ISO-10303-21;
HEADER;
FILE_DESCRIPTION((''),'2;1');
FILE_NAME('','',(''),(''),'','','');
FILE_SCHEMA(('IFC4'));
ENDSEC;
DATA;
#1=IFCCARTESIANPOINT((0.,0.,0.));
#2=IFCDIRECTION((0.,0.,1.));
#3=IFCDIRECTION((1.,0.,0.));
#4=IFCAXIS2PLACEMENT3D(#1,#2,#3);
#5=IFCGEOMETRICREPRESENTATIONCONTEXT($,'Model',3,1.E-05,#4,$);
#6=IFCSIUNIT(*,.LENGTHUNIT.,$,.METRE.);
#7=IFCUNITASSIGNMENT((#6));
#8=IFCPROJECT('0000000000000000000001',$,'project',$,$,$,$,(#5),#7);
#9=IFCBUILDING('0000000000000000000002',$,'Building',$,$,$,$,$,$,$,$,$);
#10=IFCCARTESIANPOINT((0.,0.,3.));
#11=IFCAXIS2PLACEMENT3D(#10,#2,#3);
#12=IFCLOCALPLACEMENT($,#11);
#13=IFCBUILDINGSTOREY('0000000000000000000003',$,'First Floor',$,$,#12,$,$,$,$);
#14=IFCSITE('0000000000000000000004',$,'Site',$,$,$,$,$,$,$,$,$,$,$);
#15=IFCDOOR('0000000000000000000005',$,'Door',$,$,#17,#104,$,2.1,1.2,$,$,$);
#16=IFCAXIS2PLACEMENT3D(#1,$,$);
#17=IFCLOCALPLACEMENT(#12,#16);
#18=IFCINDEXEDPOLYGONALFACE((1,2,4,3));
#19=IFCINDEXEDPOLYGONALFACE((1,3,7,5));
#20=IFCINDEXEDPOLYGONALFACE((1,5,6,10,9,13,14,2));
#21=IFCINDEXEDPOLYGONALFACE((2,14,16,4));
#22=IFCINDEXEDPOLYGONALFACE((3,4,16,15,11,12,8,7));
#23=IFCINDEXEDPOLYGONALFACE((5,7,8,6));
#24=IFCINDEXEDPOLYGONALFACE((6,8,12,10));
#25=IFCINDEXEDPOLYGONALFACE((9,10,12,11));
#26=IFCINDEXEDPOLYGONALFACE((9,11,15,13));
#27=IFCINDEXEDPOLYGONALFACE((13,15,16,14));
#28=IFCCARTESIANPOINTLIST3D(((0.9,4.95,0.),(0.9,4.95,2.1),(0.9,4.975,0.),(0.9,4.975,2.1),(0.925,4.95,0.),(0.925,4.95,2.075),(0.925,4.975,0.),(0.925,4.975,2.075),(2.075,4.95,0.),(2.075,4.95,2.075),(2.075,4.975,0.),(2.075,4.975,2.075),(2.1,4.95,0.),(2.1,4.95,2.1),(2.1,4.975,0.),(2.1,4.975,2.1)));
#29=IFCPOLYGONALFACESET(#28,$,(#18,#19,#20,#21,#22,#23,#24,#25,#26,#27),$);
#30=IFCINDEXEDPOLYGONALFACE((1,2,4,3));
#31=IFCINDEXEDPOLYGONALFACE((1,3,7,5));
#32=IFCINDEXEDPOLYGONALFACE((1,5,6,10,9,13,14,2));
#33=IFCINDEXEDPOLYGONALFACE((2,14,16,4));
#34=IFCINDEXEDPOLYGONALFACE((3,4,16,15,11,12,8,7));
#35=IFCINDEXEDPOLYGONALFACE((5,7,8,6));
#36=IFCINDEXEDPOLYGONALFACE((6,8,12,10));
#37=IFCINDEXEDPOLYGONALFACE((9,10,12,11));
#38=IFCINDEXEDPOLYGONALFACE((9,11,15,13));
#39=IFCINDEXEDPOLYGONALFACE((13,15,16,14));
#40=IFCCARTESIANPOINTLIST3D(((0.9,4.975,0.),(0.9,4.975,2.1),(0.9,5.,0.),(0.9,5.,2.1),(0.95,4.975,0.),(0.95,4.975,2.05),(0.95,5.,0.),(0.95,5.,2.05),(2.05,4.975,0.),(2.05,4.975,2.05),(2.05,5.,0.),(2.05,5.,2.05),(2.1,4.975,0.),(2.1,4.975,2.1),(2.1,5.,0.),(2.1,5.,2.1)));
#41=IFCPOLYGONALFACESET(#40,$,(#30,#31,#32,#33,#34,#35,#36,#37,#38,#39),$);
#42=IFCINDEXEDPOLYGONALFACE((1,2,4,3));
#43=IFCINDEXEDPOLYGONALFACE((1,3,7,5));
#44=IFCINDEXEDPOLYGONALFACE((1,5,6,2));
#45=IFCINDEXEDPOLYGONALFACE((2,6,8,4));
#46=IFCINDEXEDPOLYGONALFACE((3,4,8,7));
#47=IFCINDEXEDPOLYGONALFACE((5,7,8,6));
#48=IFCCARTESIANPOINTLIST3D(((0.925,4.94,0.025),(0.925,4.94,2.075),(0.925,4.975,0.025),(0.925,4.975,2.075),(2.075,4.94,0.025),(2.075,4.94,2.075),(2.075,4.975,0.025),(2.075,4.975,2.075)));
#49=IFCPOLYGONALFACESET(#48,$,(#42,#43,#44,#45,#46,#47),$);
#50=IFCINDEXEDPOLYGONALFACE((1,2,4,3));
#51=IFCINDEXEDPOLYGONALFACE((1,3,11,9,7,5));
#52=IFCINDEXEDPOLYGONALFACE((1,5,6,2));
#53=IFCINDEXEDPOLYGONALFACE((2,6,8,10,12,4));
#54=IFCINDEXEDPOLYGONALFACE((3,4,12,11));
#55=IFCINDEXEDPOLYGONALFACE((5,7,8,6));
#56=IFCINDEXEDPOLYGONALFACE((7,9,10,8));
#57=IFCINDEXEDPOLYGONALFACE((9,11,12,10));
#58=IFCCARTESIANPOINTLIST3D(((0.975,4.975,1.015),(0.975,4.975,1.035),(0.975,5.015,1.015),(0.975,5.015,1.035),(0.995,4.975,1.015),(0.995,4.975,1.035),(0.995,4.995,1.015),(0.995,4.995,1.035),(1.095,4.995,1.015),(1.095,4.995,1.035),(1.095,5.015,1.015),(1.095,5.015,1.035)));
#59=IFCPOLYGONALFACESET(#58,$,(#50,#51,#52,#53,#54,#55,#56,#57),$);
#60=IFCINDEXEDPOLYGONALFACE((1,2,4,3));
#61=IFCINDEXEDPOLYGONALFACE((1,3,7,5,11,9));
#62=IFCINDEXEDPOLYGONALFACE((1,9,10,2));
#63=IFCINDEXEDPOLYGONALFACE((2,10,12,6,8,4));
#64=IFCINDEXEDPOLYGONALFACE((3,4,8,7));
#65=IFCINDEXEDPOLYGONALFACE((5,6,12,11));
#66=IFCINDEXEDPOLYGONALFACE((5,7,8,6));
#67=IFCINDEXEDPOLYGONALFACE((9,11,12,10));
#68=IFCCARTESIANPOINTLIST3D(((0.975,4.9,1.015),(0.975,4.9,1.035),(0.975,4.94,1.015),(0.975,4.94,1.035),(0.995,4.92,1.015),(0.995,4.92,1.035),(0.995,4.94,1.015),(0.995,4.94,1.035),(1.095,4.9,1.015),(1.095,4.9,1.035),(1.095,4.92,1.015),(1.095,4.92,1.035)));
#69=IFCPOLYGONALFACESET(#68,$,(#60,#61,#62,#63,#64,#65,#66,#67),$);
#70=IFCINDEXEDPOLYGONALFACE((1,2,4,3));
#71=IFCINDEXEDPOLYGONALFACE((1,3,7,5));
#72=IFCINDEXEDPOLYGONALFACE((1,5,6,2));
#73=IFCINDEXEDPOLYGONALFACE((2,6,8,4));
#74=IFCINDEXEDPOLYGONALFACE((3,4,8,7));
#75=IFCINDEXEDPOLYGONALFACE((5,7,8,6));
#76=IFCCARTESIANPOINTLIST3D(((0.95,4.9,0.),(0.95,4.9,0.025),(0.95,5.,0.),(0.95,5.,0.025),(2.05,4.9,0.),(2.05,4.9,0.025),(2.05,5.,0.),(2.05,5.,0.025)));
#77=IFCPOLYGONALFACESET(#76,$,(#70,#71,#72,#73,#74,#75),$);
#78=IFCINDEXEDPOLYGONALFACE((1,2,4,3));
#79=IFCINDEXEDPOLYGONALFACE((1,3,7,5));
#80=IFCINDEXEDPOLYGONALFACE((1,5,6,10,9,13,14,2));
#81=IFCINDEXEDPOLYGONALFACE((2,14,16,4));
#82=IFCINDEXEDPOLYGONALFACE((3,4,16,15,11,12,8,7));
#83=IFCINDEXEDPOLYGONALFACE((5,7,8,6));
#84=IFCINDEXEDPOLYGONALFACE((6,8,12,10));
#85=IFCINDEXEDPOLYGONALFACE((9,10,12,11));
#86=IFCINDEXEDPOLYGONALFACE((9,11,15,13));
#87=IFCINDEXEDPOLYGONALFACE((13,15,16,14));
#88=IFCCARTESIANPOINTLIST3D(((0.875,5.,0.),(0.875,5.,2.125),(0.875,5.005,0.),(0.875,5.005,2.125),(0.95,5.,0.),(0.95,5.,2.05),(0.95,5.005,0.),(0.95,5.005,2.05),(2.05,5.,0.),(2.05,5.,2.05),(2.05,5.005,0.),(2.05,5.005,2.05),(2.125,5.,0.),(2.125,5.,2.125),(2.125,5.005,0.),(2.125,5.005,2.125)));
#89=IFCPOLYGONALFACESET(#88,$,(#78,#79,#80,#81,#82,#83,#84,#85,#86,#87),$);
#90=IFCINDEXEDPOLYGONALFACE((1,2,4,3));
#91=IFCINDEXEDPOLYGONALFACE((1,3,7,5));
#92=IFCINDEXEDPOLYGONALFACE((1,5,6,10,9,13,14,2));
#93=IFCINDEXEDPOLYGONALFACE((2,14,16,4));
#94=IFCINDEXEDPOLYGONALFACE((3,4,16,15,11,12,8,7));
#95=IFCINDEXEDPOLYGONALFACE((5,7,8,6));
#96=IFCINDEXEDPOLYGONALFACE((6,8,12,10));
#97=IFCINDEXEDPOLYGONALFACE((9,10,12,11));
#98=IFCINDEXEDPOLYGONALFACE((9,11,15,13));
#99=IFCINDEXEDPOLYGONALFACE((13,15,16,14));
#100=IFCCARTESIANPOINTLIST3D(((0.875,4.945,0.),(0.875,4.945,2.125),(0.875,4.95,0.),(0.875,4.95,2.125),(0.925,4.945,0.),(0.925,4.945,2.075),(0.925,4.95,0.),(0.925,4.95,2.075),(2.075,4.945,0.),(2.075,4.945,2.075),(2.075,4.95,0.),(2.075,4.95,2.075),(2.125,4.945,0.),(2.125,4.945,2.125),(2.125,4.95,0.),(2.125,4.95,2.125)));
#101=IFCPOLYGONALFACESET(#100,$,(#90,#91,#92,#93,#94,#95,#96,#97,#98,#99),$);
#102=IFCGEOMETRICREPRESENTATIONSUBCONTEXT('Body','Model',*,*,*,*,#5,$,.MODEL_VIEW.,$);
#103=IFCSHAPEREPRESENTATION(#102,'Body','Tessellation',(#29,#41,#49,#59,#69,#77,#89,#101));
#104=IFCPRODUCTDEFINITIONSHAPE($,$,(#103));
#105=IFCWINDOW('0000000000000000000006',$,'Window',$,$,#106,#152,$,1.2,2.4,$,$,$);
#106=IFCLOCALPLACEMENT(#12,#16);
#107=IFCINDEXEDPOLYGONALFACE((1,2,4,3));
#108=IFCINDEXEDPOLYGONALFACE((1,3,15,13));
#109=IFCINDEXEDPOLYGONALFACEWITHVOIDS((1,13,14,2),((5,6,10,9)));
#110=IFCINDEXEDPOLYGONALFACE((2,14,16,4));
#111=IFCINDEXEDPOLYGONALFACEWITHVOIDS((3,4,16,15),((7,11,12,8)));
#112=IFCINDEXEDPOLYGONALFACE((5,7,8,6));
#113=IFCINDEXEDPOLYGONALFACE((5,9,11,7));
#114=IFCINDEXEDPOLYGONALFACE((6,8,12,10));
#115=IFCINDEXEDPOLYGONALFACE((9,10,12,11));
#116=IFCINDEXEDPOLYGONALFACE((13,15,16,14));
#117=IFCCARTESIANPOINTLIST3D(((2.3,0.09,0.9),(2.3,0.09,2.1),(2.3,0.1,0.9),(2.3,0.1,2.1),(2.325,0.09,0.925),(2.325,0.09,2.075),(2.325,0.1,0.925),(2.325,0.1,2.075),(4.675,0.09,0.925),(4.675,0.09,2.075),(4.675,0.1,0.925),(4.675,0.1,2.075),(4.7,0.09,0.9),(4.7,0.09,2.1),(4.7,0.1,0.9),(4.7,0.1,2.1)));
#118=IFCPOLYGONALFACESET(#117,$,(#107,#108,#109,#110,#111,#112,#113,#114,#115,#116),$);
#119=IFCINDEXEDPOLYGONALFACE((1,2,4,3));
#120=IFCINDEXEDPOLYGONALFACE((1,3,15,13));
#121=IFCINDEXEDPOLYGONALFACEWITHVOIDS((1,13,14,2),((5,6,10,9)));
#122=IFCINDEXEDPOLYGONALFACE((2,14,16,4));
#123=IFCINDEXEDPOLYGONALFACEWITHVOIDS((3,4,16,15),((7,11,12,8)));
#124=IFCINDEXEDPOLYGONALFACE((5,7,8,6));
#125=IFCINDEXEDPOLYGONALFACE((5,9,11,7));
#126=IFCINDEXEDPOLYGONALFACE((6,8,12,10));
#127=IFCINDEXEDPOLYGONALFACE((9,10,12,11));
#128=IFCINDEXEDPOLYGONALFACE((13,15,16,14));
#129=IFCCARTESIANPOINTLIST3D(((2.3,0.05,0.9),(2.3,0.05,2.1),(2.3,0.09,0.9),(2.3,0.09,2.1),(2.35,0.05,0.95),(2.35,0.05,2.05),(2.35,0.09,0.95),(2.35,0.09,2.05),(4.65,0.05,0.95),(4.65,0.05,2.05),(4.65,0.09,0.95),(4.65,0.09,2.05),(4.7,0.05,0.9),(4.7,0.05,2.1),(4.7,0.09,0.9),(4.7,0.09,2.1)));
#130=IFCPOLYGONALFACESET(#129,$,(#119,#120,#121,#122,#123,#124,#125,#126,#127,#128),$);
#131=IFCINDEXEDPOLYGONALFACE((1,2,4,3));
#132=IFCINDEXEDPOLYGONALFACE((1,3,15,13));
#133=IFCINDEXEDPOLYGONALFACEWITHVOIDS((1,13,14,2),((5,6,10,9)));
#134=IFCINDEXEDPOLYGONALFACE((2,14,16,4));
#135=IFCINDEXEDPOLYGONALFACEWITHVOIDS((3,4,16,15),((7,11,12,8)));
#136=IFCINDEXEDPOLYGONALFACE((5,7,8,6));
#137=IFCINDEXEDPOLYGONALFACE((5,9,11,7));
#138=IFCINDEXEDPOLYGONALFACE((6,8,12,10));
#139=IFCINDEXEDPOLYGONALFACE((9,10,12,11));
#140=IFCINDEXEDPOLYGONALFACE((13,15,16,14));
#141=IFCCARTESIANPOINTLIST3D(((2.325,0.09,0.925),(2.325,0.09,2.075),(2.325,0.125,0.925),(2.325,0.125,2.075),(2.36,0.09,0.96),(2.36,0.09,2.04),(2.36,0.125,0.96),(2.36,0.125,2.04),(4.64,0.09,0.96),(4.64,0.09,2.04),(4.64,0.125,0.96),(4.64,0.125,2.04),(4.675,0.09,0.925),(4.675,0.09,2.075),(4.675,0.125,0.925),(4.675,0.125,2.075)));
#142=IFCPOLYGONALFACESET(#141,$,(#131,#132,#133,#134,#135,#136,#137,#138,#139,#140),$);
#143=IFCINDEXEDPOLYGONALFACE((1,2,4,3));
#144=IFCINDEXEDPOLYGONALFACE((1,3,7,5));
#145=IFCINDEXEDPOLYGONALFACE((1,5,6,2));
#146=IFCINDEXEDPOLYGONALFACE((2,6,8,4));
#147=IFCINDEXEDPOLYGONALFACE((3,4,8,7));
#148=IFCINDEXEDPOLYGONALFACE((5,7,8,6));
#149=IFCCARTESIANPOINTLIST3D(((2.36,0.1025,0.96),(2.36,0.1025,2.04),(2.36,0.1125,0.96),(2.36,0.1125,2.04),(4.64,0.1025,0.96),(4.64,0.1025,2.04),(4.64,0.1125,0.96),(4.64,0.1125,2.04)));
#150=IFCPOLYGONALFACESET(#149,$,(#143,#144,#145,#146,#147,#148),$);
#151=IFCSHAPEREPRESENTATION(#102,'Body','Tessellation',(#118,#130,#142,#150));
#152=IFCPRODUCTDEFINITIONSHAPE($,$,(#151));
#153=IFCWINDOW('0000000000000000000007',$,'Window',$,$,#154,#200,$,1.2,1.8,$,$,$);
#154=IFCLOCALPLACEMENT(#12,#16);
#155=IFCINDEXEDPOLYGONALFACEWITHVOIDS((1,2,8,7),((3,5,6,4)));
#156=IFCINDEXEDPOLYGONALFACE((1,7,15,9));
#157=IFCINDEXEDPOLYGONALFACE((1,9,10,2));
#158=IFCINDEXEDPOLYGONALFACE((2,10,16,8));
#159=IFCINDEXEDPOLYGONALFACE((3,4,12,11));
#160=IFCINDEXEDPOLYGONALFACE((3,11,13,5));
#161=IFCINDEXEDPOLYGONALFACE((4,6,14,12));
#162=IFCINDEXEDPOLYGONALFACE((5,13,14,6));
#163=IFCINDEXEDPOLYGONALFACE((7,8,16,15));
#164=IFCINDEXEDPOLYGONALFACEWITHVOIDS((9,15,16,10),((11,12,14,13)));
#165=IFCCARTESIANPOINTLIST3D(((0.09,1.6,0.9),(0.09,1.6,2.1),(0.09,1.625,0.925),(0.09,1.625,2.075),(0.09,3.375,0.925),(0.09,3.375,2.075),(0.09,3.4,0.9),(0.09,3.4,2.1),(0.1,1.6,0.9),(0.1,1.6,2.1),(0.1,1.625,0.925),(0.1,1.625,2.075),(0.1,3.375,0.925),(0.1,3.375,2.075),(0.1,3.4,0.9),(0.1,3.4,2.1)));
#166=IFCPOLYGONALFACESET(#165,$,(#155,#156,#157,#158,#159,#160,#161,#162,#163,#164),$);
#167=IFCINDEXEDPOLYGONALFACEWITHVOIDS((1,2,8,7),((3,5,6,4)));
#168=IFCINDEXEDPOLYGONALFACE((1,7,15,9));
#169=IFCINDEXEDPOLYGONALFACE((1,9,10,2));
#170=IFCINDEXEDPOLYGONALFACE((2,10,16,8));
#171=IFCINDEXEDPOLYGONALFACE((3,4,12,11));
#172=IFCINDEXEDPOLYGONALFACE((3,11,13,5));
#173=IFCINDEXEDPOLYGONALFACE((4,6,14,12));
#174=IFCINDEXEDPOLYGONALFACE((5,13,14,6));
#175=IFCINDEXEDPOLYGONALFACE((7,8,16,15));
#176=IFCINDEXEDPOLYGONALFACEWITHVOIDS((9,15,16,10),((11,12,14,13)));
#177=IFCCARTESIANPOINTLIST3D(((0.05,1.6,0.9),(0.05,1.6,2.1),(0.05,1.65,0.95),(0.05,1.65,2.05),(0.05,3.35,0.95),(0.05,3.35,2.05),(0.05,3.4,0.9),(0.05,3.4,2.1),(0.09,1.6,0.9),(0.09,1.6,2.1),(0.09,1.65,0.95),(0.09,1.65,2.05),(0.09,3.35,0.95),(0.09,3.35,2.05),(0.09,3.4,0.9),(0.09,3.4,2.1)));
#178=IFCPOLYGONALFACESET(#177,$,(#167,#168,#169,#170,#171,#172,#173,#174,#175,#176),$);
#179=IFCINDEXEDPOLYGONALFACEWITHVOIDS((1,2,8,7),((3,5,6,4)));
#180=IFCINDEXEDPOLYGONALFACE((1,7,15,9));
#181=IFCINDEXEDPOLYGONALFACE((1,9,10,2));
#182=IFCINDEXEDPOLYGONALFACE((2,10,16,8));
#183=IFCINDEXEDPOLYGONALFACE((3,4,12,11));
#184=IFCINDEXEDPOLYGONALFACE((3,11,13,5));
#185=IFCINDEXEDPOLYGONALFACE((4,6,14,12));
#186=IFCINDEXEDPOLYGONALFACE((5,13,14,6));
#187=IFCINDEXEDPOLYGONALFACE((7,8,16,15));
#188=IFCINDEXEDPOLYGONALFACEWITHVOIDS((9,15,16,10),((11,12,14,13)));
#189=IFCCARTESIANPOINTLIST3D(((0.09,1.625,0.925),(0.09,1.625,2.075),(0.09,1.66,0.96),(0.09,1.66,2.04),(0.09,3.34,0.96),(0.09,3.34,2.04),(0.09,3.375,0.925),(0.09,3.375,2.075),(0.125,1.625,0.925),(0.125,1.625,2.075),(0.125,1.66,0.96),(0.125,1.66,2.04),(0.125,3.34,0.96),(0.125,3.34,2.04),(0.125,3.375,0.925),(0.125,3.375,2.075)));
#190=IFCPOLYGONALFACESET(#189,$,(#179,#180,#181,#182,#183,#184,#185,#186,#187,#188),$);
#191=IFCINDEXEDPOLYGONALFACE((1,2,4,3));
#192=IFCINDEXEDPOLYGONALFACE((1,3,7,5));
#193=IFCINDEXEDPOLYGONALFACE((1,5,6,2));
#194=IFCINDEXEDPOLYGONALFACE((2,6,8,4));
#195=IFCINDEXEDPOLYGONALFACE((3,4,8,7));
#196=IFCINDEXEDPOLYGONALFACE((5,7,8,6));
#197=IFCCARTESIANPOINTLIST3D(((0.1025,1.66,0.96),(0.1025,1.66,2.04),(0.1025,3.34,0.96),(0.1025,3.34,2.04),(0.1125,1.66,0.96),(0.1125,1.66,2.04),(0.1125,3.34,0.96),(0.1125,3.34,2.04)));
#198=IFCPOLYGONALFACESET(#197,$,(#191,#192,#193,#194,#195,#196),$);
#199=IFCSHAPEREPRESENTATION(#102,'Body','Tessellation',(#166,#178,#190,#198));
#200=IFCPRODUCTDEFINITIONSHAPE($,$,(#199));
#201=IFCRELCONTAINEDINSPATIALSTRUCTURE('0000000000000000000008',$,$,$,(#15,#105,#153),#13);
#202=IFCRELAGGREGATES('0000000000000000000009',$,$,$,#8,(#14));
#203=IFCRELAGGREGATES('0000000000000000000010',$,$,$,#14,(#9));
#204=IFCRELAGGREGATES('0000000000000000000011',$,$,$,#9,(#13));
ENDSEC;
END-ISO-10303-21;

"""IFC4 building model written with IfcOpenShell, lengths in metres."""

from ifc_helpers import new_model, si_unit, frame, origin_with_axes, place, context, subcontext, project, spatial, line, indexed_curve, outline, extrude, element, save


model = new_model("IFC4")

# Units and contexts
model_context = context("Model", 3, precision=1e-05, world=origin_with_axes())
body_context = subcontext(model_context, "Body", "Model", "MODEL_VIEW")
ifc_project = project(units=[si_unit("LENGTHUNIT", "METRE")], contexts=[model_context])

# Site, building, storey
site = spatial("IfcSite", under=ifc_project, Name="Site")
building = spatial("IfcBuilding", under=site, Name="Building")
storey_placement = place(None, frame((0.0, 0.0, 3.0), z_axis=(0.0, 0.0, 1.0), x_axis=(1.0, 0.0, 0.0)))
storey = spatial("IfcBuildingStorey", under=building, at=storey_placement, Name="First Floor")

# Door
door_1_placement = place(storey_placement, frame((2.1, 5.0, 0.0), z_axis=(0.0, 0.0, 1.0), x_axis=(-1.0, 0.0, 0.0)))
element("IfcDoor", 1, at=door_1_placement, inside=storey, Name="Door", OverallHeight=2.1, OverallWidth=1.2, context=body_context, shape_type="SweptSolid", body=[
    extrude(outline(indexed_curve([(0.0, 0.0), (0.0, 2.1), (1.2, 2.1), (1.2, 0.0), (1.175, 0.0), (1.175, 2.075), (0.025, 2.075), (0.025, 0.0)], segments=[line(1, 2, 3, 4, 5, 6, 7, 8, 1)])), frame((0.0, 0.025, 0.0), z_axis=(0.0, -1.0, 0.0), x_axis=(1.0, 0.0, 0.0)), (0.0, 0.0, -1.0), 0.025),
    extrude(outline(indexed_curve([(0.0, 0.0), (0.0, 2.1), (1.2, 2.1), (1.2, 0.0), (1.15, 0.0), (1.15, 2.05), (0.05, 2.05), (0.05, 0.0)], segments=[line(1, 2, 3, 4, 5, 6, 7, 8, 1)])), frame((0.0, 0.0, 0.0), z_axis=(0.0, -1.0, 0.0), x_axis=(1.0, 0.0, 0.0)), (0.0, 0.0, -1.0), 0.025),
    extrude(outline(indexed_curve([(0.0, 0.0), (1.15, 0.0), (1.15, 0.035), (0.0, 0.035)], segments=[line(1, 2, 3, 4, 1)])), frame((0.025, 0.025, 0.025), z_axis=(0.0, 0.0, 1.0), x_axis=(1.0, 0.0, 0.0)), (0.0, 0.0, 1.0), 2.05),
    extrude(outline(indexed_curve([(0.0, 0.0), (0.0, -0.04), (-0.12, -0.04), (-0.12, -0.02), (-0.02, -0.02), (-0.02, 0.0)], segments=[line(1, 2, 3, 4, 5, 6, 1)])), frame((1.125, 0.025, 1.015), z_axis=(0.0, 0.0, 1.0), x_axis=(1.0, 0.0, 0.0)), (0.0, 0.0, 1.0), 0.02),
    extrude(outline(indexed_curve([(0.0, 0.0), (0.0, 0.04), (-0.12, 0.04), (-0.12, 0.02), (-0.02, 0.02), (-0.02, 0.0)], segments=[line(1, 2, 3, 4, 5, 6, 1)])), frame((1.125, 0.06, 1.015), z_axis=(0.0, 0.0, 1.0), x_axis=(1.0, 0.0, 0.0)), (0.0, 0.0, 1.0), 0.02),
    extrude(outline(indexed_curve([(0.0, 0.0), (1.1, 0.0), (1.1, 0.1), (0.0, 0.1)], segments=[line(1, 2, 3, 4, 1)])), frame((0.05, 0.0, 0.0), z_axis=(0.0, 0.0, 1.0), x_axis=(1.0, 0.0, 0.0)), (0.0, 0.0, 1.0), 0.025),
    extrude(outline(indexed_curve([(0.0, 0.0), (0.0, 2.125), (1.25, 2.125), (1.25, 0.0), (1.175, 0.0), (1.175, 2.05), (0.075, 2.05), (0.075, 0.0)], segments=[line(1, 2, 3, 4, 5, 6, 7, 8, 1)])), frame((-0.025, -0.005, 0.0), z_axis=(0.0, -1.0, 0.0), x_axis=(1.0, 0.0, 0.0)), (0.0, 0.0, -1.0), 0.005),
    extrude(outline(indexed_curve([(0.0, 0.0), (0.0, 2.125), (1.25, 2.125), (1.25, 0.0), (1.2, 0.0), (1.2, 2.075), (0.05, 2.075), (0.05, 0.0)], segments=[line(1, 2, 3, 4, 5, 6, 7, 8, 1)])), frame((-0.025, 0.05, 0.0), z_axis=(0.0, -1.0, 0.0), x_axis=(1.0, 0.0, 0.0)), (0.0, 0.0, -1.0), 0.005),
])

# Windows
window_1_placement = place(storey_placement, frame((2.3, 0.0, 0.9), z_axis=(0.0, 0.0, 1.0), x_axis=(1.0, 0.0, 0.0)))
element("IfcWindow", 2, at=window_1_placement, inside=storey, Name="Window", OverallHeight=1.2, OverallWidth=2.4, context=body_context, shape_type="SweptSolid", body=[
    extrude(outline(indexed_curve([(0.0, 0.0), (2.4, 0.0), (2.4, 1.2), (0.0, 1.2)], segments=[line(1, 2, 3, 4, 1)]), holes=[indexed_curve([(0.025, 0.025), (2.375, 0.025), (2.375, 1.175), (0.025, 1.175)], segments=[line(1, 2, 3, 4, 1)])]), frame((0.0, 0.09, 0.0), z_axis=(0.0, -1.0, 0.0), x_axis=(1.0, 0.0, 0.0)), (0.0, 0.0, -1.0), 0.01),
    extrude(outline(indexed_curve([(0.0, 0.0), (2.4, 0.0), (2.4, 1.2), (0.0, 1.2)], segments=[line(1, 2, 3, 4, 1)]), holes=[indexed_curve([(0.05, 0.05), (2.35, 0.05), (2.35, 1.15), (0.05, 1.15)], segments=[line(1, 2, 3, 4, 1)])]), frame((0.0, 0.05, 0.0), z_axis=(0.0, -1.0, 0.0), x_axis=(1.0, 0.0, 0.0)), (0.0, 0.0, -1.0), 0.04),
    extrude(outline(indexed_curve([(0.0, 0.0), (2.35, 0.0), (2.35, 1.15), (0.0, 1.15)], segments=[line(1, 2, 3, 4, 1)]), holes=[indexed_curve([(0.035, 0.035), (2.315, 0.035), (2.315, 1.115), (0.035, 1.115)], segments=[line(1, 2, 3, 4, 1)])]), frame((0.025, 0.09, 0.025), z_axis=(0.0, -1.0, 0.0), x_axis=(1.0, 0.0, 0.0)), (0.0, 0.0, -1.0), 0.035),
    extrude(outline(indexed_curve([(0.035, 0.035), (2.315, 0.035), (2.315, 1.115), (0.035, 1.115)], segments=[line(1, 2, 3, 4, 1)])), frame((0.025, 0.1025, 0.025), z_axis=(0.0, -1.0, 0.0), x_axis=(1.0, 0.0, 0.0)), (0.0, 0.0, -1.0), 0.01),
])
for number, where, z_axis, x_axis, name in (
    (3, (0.0, 3.4, 0.9), (0.0, 0.0, 1.0), (0.0, -1.0, 0.0), "Window"),
):
    element("IfcWindow", number, at=place(storey_placement, frame(where, z_axis=z_axis, x_axis=x_axis)), inside=storey, Name=name, OverallHeight=1.2, OverallWidth=1.8, context=body_context, shape_type="SweptSolid", body=[
        extrude(outline(indexed_curve([(0.0, 0.0), (1.8, 0.0), (1.8, 1.2), (0.0, 1.2)], segments=[line(1, 2, 3, 4, 1)]), holes=[indexed_curve([(0.025, 0.025), (1.775, 0.025), (1.775, 1.175), (0.025, 1.175)], segments=[line(1, 2, 3, 4, 1)])]), frame((0.0, 0.09, 0.0), z_axis=(0.0, -1.0, 0.0), x_axis=(1.0, 0.0, 0.0)), (0.0, 0.0, -1.0), 0.01),
        extrude(outline(indexed_curve([(0.0, 0.0), (1.8, 0.0), (1.8, 1.2), (0.0, 1.2)], segments=[line(1, 2, 3, 4, 1)]), holes=[indexed_curve([(0.05, 0.05), (1.75, 0.05), (1.75, 1.15), (0.05, 1.15)], segments=[line(1, 2, 3, 4, 1)])]), frame((0.0, 0.05, 0.0), z_axis=(0.0, -1.0, 0.0), x_axis=(1.0, 0.0, 0.0)), (0.0, 0.0, -1.0), 0.04),
        extrude(outline(indexed_curve([(0.0, 0.0), (1.75, 0.0), (1.75, 1.15), (0.0, 1.15)], segments=[line(1, 2, 3, 4, 1)]), holes=[indexed_curve([(0.035, 0.035), (1.715, 0.035), (1.715, 1.115), (0.035, 1.115)], segments=[line(1, 2, 3, 4, 1)])]), frame((0.025, 0.09, 0.025), z_axis=(0.0, -1.0, 0.0), x_axis=(1.0, 0.0, 0.0)), (0.0, 0.0, -1.0), 0.035),
        extrude(outline(indexed_curve([(0.035, 0.035), (1.715, 0.035), (1.715, 1.115), (0.035, 1.115)], segments=[line(1, 2, 3, 4, 1)])), frame((0.025, 0.1025, 0.025), z_axis=(0.0, -1.0, 0.0), x_axis=(1.0, 0.0, 0.0)), (0.0, 0.0, -1.0), 0.01),
    ])

save(model, "model.ifc")
